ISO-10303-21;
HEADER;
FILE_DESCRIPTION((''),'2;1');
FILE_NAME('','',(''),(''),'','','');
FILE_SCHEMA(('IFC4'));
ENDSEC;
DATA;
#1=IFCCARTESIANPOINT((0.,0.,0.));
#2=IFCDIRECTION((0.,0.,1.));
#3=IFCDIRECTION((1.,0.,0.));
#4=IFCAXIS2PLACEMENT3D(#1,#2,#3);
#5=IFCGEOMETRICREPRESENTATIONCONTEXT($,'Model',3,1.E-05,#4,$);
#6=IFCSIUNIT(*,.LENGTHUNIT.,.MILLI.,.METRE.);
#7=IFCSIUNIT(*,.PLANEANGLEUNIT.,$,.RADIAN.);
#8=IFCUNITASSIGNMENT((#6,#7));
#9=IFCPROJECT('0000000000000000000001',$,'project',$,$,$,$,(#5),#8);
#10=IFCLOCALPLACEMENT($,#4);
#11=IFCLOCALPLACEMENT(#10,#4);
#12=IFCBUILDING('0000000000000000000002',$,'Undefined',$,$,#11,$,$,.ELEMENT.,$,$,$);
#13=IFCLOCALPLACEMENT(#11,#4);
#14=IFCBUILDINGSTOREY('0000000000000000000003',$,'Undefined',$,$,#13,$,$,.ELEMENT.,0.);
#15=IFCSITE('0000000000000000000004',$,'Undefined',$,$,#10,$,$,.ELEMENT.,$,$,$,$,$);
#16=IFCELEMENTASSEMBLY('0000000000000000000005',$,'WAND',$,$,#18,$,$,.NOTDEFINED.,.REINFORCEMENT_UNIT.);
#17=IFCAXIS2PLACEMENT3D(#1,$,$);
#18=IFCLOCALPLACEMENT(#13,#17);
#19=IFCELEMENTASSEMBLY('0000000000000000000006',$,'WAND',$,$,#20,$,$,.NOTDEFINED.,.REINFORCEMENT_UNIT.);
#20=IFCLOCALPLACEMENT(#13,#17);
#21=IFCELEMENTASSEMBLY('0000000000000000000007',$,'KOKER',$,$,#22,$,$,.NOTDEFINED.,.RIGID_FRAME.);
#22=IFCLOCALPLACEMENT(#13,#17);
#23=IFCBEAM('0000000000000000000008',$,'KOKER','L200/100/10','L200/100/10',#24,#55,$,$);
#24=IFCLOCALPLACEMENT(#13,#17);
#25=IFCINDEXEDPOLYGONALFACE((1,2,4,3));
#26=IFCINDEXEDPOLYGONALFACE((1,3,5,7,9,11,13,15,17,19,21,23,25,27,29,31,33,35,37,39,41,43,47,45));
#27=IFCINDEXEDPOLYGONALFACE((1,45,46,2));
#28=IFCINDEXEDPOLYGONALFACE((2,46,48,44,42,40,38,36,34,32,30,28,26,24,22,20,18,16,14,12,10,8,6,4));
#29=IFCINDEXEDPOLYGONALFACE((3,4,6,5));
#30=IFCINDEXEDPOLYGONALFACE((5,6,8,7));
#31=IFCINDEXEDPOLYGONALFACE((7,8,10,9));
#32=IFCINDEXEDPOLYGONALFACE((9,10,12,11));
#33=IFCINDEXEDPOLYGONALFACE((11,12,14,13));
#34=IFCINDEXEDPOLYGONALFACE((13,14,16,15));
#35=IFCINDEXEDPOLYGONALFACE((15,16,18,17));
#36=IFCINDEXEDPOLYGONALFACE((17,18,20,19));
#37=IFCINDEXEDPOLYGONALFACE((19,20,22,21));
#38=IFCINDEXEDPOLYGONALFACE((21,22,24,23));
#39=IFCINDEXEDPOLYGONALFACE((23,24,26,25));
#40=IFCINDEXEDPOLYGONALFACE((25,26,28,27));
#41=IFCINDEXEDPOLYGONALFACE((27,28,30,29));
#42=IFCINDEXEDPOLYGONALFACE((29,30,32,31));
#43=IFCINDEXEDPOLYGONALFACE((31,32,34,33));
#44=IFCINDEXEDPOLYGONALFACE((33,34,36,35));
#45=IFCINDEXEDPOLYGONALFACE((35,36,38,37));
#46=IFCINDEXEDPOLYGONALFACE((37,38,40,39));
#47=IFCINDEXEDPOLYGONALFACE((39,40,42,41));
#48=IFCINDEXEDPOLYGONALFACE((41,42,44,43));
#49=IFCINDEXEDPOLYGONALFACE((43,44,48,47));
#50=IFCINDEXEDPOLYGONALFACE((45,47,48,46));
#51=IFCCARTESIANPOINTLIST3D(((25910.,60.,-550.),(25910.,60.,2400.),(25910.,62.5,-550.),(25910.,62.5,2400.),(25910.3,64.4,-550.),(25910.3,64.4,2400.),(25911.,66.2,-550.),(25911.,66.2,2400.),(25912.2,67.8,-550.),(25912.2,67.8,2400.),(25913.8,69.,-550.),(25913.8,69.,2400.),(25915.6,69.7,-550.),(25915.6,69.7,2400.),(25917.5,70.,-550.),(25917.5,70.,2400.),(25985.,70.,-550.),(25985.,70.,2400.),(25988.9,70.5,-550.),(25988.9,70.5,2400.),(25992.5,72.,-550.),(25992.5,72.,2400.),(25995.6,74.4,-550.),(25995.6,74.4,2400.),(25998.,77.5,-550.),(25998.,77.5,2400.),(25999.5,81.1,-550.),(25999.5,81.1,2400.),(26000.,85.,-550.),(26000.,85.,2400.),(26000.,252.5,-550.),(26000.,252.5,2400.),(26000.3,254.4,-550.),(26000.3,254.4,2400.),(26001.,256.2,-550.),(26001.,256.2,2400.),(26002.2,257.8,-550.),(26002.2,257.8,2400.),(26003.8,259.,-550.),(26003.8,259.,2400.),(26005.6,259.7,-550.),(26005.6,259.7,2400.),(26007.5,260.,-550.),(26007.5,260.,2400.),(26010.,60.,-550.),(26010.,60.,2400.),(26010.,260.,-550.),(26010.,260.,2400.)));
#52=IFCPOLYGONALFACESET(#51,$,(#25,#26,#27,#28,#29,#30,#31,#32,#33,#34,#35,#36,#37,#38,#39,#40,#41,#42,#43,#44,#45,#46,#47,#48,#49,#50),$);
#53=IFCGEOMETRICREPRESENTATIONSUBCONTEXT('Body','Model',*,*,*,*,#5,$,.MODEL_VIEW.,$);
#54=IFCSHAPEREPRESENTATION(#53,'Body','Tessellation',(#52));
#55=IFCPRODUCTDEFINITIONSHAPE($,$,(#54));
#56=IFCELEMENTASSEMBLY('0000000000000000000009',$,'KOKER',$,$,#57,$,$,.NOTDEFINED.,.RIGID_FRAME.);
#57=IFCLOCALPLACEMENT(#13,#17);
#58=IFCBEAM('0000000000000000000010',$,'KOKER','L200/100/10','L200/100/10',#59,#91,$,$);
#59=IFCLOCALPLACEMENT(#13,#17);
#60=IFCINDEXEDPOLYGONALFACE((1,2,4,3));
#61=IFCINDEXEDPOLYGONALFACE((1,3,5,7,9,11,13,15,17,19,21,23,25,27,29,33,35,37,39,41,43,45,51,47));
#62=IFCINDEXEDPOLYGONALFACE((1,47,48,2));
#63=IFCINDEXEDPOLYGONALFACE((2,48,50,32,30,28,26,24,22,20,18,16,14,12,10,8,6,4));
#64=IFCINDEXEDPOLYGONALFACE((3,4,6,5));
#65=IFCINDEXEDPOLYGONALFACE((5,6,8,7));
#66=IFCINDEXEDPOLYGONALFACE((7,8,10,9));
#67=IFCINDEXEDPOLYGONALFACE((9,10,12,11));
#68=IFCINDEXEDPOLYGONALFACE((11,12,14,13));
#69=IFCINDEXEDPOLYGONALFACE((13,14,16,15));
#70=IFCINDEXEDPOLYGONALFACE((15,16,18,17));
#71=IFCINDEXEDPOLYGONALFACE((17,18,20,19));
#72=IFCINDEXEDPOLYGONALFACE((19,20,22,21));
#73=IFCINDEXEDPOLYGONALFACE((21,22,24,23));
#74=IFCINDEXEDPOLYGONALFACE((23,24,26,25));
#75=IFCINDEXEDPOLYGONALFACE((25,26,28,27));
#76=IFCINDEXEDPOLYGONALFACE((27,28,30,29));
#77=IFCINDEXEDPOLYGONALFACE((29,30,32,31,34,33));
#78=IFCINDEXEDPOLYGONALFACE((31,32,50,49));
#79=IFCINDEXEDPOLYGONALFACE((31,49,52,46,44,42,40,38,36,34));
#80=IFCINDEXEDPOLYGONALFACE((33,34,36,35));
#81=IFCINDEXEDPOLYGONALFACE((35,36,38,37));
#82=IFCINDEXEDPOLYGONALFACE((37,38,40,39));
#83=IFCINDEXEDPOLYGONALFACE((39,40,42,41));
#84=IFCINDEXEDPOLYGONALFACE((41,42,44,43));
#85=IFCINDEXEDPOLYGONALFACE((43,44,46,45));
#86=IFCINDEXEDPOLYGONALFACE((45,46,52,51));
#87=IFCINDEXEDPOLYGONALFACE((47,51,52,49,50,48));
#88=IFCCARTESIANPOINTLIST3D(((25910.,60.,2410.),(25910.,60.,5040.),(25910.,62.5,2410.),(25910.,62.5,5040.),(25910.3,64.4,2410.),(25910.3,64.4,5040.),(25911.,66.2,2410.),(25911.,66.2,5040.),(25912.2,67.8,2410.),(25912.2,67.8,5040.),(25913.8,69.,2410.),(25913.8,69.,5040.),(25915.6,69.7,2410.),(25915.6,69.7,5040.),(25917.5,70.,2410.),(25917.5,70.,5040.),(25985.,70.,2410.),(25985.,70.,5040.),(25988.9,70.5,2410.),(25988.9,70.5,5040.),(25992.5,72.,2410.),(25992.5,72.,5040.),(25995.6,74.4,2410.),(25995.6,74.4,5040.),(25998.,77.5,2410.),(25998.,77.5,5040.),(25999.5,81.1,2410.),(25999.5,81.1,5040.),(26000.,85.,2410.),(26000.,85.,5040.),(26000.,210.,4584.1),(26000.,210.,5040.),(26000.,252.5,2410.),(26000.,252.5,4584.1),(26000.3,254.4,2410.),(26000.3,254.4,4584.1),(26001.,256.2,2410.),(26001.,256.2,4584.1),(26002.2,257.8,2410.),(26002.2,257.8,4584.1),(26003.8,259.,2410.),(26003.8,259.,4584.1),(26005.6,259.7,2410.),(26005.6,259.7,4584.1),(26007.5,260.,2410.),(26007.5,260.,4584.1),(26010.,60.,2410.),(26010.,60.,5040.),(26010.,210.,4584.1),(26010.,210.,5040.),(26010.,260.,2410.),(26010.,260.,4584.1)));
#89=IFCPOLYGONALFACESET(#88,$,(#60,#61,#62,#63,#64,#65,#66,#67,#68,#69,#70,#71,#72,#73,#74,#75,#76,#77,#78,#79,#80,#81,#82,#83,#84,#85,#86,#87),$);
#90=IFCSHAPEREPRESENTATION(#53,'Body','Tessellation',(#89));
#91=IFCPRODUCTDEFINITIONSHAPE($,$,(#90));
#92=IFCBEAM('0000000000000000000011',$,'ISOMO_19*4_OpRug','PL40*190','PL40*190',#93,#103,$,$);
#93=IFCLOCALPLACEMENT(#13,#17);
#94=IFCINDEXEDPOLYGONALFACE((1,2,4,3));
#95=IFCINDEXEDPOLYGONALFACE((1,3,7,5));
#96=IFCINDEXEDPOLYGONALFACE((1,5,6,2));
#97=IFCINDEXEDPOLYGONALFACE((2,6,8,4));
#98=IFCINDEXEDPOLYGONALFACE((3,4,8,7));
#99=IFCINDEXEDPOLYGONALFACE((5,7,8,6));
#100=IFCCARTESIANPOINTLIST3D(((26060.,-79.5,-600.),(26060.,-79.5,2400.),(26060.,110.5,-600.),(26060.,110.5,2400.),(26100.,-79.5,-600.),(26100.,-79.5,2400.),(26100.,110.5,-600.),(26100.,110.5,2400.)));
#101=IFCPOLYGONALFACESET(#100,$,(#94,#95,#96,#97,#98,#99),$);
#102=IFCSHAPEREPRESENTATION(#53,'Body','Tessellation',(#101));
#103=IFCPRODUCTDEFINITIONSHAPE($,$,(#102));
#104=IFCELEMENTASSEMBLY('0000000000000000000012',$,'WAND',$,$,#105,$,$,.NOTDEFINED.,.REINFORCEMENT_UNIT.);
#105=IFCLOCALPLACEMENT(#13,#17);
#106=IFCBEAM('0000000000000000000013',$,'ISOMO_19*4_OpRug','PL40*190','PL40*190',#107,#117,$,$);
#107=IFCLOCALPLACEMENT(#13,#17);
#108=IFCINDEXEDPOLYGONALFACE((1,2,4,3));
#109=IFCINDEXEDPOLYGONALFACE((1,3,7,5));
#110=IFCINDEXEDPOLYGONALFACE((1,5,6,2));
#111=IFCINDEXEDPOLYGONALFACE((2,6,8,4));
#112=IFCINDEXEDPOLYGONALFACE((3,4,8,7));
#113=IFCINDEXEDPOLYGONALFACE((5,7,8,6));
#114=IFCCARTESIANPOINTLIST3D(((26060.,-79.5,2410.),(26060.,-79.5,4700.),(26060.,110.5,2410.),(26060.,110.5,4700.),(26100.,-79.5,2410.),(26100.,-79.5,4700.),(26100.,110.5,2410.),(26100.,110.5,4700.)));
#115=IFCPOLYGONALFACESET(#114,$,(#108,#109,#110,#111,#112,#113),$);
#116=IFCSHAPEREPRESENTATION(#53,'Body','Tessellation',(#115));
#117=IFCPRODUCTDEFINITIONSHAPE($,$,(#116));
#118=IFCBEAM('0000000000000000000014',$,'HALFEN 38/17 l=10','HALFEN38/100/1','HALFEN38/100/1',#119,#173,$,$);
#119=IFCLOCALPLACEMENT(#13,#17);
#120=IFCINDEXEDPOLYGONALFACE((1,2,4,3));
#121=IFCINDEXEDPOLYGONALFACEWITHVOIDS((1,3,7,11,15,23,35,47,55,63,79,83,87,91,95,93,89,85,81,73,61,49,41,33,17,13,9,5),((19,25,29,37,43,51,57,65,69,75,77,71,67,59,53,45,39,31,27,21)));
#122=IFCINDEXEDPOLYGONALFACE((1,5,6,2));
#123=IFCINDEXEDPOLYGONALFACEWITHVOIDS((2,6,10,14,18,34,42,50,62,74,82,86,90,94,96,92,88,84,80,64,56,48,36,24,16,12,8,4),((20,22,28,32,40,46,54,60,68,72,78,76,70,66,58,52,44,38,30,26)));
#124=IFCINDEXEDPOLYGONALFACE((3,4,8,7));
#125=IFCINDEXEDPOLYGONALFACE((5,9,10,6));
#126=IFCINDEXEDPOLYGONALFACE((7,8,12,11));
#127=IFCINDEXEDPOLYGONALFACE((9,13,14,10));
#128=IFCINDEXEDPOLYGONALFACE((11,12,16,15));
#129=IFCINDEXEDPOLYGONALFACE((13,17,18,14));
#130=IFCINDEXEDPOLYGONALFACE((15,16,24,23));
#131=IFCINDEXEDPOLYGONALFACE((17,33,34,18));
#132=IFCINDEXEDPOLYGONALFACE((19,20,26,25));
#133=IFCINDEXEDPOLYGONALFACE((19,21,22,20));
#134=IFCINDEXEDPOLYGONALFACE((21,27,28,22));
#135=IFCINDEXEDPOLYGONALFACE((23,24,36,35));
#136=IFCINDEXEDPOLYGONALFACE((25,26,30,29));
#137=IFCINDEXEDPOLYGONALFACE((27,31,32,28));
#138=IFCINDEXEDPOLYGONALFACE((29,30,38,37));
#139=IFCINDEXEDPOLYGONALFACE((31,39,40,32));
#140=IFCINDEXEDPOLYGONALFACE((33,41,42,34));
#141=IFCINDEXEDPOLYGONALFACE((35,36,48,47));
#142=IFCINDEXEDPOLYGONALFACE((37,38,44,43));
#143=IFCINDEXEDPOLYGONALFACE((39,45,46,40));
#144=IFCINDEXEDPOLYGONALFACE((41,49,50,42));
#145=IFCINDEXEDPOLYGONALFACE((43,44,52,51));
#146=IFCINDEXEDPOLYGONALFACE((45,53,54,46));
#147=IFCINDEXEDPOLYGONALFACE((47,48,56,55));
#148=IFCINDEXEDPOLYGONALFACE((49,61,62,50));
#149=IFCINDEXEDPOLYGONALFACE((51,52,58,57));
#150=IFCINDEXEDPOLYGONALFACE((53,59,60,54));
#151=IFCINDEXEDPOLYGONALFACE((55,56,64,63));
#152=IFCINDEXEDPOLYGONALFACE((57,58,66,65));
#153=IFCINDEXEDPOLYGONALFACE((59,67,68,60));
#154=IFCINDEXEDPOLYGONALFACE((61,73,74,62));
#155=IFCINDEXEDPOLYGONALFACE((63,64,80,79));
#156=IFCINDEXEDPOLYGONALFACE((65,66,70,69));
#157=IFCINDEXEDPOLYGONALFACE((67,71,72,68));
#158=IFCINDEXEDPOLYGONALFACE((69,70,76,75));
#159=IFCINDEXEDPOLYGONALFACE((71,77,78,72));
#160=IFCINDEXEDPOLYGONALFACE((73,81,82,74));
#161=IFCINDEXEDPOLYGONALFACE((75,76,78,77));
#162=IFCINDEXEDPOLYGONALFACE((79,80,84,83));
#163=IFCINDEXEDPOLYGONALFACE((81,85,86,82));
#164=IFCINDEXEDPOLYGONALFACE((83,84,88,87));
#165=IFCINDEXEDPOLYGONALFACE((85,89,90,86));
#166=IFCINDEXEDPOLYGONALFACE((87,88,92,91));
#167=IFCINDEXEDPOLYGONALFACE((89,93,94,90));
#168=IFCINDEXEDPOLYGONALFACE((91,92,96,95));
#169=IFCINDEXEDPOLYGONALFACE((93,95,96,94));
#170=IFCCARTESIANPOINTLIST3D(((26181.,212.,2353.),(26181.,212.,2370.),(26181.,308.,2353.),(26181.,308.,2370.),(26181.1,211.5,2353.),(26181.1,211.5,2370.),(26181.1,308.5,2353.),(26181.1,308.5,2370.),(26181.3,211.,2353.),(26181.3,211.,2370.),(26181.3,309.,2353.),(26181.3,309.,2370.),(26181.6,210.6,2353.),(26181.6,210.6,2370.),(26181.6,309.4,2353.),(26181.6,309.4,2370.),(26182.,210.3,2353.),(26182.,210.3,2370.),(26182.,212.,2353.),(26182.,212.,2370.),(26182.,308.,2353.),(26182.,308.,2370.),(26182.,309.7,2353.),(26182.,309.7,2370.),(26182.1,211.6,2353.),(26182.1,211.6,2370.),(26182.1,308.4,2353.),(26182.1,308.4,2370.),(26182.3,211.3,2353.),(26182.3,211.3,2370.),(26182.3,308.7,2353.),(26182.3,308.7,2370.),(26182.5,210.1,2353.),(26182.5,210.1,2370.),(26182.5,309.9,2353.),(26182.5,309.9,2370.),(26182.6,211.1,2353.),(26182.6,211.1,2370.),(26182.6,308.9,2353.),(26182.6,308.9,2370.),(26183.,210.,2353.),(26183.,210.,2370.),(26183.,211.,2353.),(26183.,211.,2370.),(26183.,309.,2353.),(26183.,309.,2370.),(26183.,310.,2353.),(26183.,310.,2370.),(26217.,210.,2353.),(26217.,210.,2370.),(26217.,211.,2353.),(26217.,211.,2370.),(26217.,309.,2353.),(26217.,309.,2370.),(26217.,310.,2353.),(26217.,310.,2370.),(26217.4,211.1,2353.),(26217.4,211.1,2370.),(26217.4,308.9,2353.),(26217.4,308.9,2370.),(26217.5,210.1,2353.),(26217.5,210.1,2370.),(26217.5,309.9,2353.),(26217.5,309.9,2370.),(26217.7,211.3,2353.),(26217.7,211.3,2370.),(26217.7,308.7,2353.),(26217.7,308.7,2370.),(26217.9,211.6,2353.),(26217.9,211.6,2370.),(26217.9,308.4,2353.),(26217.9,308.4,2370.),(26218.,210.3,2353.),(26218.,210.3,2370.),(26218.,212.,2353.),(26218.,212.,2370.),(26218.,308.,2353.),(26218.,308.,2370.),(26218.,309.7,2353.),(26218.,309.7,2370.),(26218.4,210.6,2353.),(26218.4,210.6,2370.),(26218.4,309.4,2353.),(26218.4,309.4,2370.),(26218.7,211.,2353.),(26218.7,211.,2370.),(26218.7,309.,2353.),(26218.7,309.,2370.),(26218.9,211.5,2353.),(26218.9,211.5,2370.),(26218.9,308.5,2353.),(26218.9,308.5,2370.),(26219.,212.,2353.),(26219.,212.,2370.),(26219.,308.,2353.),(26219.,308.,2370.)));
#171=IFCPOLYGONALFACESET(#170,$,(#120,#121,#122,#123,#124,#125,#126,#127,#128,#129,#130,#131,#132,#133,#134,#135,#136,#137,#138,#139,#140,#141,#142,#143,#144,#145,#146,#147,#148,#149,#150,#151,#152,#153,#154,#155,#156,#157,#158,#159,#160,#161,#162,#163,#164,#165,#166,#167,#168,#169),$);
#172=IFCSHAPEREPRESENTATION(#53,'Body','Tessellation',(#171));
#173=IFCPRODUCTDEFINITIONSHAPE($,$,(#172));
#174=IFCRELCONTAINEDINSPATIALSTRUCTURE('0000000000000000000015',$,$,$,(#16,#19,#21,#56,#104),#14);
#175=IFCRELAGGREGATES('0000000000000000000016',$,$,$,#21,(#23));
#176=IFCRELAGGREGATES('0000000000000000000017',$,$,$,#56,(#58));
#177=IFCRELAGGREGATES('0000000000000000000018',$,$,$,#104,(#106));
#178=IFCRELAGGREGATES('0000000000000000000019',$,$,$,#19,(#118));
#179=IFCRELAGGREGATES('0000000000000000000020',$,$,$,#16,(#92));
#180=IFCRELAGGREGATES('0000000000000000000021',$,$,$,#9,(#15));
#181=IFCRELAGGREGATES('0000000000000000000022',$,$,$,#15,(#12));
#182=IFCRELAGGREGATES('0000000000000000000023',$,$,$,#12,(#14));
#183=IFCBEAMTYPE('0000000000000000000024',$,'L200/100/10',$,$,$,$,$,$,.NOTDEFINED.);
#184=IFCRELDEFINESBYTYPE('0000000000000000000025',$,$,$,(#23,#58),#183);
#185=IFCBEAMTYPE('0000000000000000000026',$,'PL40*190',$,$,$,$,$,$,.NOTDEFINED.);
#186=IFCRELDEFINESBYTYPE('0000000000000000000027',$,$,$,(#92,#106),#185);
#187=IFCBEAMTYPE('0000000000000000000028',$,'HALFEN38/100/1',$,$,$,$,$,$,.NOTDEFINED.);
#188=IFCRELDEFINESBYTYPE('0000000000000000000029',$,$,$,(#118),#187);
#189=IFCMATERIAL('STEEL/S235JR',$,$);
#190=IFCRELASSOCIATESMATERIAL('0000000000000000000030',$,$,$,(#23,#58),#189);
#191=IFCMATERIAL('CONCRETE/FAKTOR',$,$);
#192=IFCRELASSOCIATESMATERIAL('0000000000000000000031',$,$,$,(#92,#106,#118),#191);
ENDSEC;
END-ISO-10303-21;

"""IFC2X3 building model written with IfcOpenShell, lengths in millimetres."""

from ifc_helpers import new_model, si_unit, frame, frame_2d, origin_with_axes, place, context, subcontext, project, spatial, rectangle, hollow_rectangle, l_section, extrude, boolean, material, type_object, element, aggregate, save


model = new_model("IFC2X3")

# Units and contexts
model_context = context("Model", 3, precision=1e-05, world=origin_with_axes())
body_context = subcontext(model_context, "Body", "Model", "MODEL_VIEW")
ifc_project = project(units=[si_unit("LENGTHUNIT", "METRE", prefix="MILLI"), si_unit("PLANEANGLEUNIT", "RADIAN")], contexts=[model_context])

# Site, building, storey
site_placement = place(None, origin_with_axes())
site = spatial("IfcSite", under=ifc_project, at=site_placement, Name="Undefined", CompositionType="ELEMENT")
building_placement = place(site_placement, origin_with_axes())
building = spatial("IfcBuilding", under=site, at=building_placement, Name="Undefined", CompositionType="ELEMENT")
storey_placement = place(building_placement, origin_with_axes())
storey = spatial("IfcBuildingStorey", under=building, at=storey_placement, Name="Undefined", CompositionType="ELEMENT", Elevation=0.0)

# Shared definitions
ifc_material_1 = material(Name="CONCRETE/FAKTOR")

# Element assembly
assembly_1_placement = place(storey_placement, origin_with_axes())
assembly_1 = element("IfcElementAssembly", 1, at=assembly_1_placement, inside=storey, Name="WAND", AssemblyPlace="NOTDEFINED", PredefinedType="REINFORCEMENT_UNIT")

# Element assembly
assembly_2_placement = place(storey_placement, origin_with_axes())
assembly_2 = element("IfcElementAssembly", 2, at=assembly_2_placement, inside=storey, Name="WAND", AssemblyPlace="NOTDEFINED", PredefinedType="REINFORCEMENT_UNIT")

# Element assemblies, beams
assembly_3_placement = place(storey_placement, origin_with_axes())
assembly_3 = element("IfcElementAssembly", 3, at=assembly_3_placement, inside=storey, Name="KOKER", AssemblyPlace="NOTDEFINED", PredefinedType="RIGID_FRAME")
ifc_material_2 = material(Name="STEEL/S235JR")
beam_type_1 = type_object("IfcBeamType", Name="L200/100/10", PredefinedType="NOTDEFINED")
beam_1_placement = place(assembly_3_placement, frame((25960.0, 160.0, -550.0), z_axis=(0.0, 1.0, 0.0), x_axis=(0.0, 0.0, 1.0)))
beam_1 = element("IfcBeam", 4, at=beam_1_placement, type_object=beam_type_1, material=ifc_material_2, Name="KOKER", Description="L200/100/10", ObjectType="L200/100/10", context=body_context, shape_type="SweptSolid", body=[
    extrude(l_section(Depth=200.0, Width=100.0, Thickness=10.0, FilletRadius=15.0, EdgeRadius=7.5, at=frame_2d((0.0, 0.0), x_axis=(1.0, 0.0))), frame((2950.0, 0.0, 0.0), z_axis=(-1.0, 0.0, 0.0), x_axis=(0.0, -1.0, 0.0)), (0.0, 0.0, 1.0), 2950.0),
])
aggregate(assembly_3, [beam_1])
assembly_4_placement = place(storey_placement, origin_with_axes())
assembly_4 = element("IfcElementAssembly", 5, at=assembly_4_placement, inside=storey, Name="KOKER", AssemblyPlace="NOTDEFINED", PredefinedType="RIGID_FRAME")
beam_2_placement = place(assembly_4_placement, frame((25960.0, 160.0, 2410.0), z_axis=(0.0, 1.0, 0.0), x_axis=(0.0, 0.0, 1.0)))
beam_2 = element("IfcBeam", 6, at=beam_2_placement, type_object=beam_type_1, material=ifc_material_2, Name="KOKER", Description="L200/100/10", ObjectType="L200/100/10", context=body_context, shape_type="CSG", body=[
    boolean("DIFFERENCE", extrude(l_section(Depth=200.0, Width=100.0, Thickness=10.0, FilletRadius=15.0, EdgeRadius=7.5, at=frame_2d((0.0, 0.0), x_axis=(1.0, 0.0))), frame((2630.0, 0.0, 0.0), z_axis=(-1.0, 0.0, 0.0), x_axis=(0.0, -1.0, 0.0)), (0.0, 0.0, 1.0), 2630.0), extrude(rectangle(XDim=100.0, YDim=150.0, at=frame_2d((0.0, 0.0), x_axis=(1.0, 0.0))), frame((2689.1, 0.0, 125.0), z_axis=(-1.0, 0.0, 0.0), x_axis=(0.0, -1.0, 0.0)), (0.0, 0.0, 1.0), 515.0)),
])
aggregate(assembly_4, [beam_2])

# Beam
beam_type_2 = type_object("IfcBeamType", Name="PL40*190", PredefinedType="NOTDEFINED")
beam_3_placement = place(assembly_1_placement, frame((26080.0, 15.5, -600.0), z_axis=(0.0, -1.0, 0.0), x_axis=(0.0, 0.0, 1.0)))
beam_3 = element("IfcBeam", 7, at=beam_3_placement, type_object=beam_type_2, material=ifc_material_1, Name="ISOMO_19*4_OpRug", Description="PL40*190", ObjectType="PL40*190", context=body_context, shape_type="SweptSolid", body=[
    extrude(rectangle(XDim=40.0, YDim=190.0, at=frame_2d((0.0, 0.0), x_axis=(1.0, 0.0))), frame((3000.0, 0.0, 0.0), z_axis=(-1.0, 0.0, 0.0), x_axis=(0.0, -1.0, 0.0)), (0.0, 0.0, 1.0), 3000.0),
])

# Element assembly, beam
assembly_5_placement = place(storey_placement, origin_with_axes())
assembly_5 = element("IfcElementAssembly", 8, at=assembly_5_placement, inside=storey, Name="WAND", AssemblyPlace="NOTDEFINED", PredefinedType="REINFORCEMENT_UNIT")
beam_4_placement = place(assembly_5_placement, frame((26080.0, 15.5, 2410.0), z_axis=(0.0, -1.0, 0.0), x_axis=(0.0, 0.0, 1.0)))
beam_4 = element("IfcBeam", 9, at=beam_4_placement, type_object=beam_type_2, material=ifc_material_1, Name="ISOMO_19*4_OpRug", Description="PL40*190", ObjectType="PL40*190", context=body_context, shape_type="SweptSolid", body=[
    extrude(rectangle(XDim=40.0, YDim=190.0, at=frame_2d((0.0, 0.0), x_axis=(1.0, 0.0))), frame((2290.0, 0.0, 0.0), z_axis=(-1.0, 0.0, 0.0), x_axis=(0.0, -1.0, 0.0)), (0.0, 0.0, 1.0), 2290.0),
])
aggregate(assembly_5, [beam_4])

# Beam
beam_type_3 = type_object("IfcBeamType", Name="HALFEN38/100/1", PredefinedType="NOTDEFINED")
beam_5_placement = place(assembly_2_placement, frame((26200.0, 260.0, 2370.0), z_axis=(-1.0, 0.0, 0.0), x_axis=(0.0, 0.0, -1.0)))
beam_5 = element("IfcBeam", 10, at=beam_5_placement, type_object=beam_type_3, material=ifc_material_1, Name="HALFEN 38/17 l=10", Description="HALFEN38/100/1", ObjectType="HALFEN38/100/1", context=body_context, shape_type="SweptSolid", body=[
    extrude(hollow_rectangle(XDim=100.0, YDim=38.0, WallThickness=1.0, InnerFilletRadius=1.0, OuterFilletRadius=2.0, at=frame_2d((0.0, 0.0), x_axis=(1.0, 0.0))), frame((17.0, 0.0, 0.0), z_axis=(-1.0, 0.0, 0.0), x_axis=(0.0, -1.0, 0.0)), (0.0, 0.0, 1.0), 17.0),
])
aggregate(assembly_2, [beam_5])
aggregate(assembly_1, [beam_3])

save(model, "model.ifc")
